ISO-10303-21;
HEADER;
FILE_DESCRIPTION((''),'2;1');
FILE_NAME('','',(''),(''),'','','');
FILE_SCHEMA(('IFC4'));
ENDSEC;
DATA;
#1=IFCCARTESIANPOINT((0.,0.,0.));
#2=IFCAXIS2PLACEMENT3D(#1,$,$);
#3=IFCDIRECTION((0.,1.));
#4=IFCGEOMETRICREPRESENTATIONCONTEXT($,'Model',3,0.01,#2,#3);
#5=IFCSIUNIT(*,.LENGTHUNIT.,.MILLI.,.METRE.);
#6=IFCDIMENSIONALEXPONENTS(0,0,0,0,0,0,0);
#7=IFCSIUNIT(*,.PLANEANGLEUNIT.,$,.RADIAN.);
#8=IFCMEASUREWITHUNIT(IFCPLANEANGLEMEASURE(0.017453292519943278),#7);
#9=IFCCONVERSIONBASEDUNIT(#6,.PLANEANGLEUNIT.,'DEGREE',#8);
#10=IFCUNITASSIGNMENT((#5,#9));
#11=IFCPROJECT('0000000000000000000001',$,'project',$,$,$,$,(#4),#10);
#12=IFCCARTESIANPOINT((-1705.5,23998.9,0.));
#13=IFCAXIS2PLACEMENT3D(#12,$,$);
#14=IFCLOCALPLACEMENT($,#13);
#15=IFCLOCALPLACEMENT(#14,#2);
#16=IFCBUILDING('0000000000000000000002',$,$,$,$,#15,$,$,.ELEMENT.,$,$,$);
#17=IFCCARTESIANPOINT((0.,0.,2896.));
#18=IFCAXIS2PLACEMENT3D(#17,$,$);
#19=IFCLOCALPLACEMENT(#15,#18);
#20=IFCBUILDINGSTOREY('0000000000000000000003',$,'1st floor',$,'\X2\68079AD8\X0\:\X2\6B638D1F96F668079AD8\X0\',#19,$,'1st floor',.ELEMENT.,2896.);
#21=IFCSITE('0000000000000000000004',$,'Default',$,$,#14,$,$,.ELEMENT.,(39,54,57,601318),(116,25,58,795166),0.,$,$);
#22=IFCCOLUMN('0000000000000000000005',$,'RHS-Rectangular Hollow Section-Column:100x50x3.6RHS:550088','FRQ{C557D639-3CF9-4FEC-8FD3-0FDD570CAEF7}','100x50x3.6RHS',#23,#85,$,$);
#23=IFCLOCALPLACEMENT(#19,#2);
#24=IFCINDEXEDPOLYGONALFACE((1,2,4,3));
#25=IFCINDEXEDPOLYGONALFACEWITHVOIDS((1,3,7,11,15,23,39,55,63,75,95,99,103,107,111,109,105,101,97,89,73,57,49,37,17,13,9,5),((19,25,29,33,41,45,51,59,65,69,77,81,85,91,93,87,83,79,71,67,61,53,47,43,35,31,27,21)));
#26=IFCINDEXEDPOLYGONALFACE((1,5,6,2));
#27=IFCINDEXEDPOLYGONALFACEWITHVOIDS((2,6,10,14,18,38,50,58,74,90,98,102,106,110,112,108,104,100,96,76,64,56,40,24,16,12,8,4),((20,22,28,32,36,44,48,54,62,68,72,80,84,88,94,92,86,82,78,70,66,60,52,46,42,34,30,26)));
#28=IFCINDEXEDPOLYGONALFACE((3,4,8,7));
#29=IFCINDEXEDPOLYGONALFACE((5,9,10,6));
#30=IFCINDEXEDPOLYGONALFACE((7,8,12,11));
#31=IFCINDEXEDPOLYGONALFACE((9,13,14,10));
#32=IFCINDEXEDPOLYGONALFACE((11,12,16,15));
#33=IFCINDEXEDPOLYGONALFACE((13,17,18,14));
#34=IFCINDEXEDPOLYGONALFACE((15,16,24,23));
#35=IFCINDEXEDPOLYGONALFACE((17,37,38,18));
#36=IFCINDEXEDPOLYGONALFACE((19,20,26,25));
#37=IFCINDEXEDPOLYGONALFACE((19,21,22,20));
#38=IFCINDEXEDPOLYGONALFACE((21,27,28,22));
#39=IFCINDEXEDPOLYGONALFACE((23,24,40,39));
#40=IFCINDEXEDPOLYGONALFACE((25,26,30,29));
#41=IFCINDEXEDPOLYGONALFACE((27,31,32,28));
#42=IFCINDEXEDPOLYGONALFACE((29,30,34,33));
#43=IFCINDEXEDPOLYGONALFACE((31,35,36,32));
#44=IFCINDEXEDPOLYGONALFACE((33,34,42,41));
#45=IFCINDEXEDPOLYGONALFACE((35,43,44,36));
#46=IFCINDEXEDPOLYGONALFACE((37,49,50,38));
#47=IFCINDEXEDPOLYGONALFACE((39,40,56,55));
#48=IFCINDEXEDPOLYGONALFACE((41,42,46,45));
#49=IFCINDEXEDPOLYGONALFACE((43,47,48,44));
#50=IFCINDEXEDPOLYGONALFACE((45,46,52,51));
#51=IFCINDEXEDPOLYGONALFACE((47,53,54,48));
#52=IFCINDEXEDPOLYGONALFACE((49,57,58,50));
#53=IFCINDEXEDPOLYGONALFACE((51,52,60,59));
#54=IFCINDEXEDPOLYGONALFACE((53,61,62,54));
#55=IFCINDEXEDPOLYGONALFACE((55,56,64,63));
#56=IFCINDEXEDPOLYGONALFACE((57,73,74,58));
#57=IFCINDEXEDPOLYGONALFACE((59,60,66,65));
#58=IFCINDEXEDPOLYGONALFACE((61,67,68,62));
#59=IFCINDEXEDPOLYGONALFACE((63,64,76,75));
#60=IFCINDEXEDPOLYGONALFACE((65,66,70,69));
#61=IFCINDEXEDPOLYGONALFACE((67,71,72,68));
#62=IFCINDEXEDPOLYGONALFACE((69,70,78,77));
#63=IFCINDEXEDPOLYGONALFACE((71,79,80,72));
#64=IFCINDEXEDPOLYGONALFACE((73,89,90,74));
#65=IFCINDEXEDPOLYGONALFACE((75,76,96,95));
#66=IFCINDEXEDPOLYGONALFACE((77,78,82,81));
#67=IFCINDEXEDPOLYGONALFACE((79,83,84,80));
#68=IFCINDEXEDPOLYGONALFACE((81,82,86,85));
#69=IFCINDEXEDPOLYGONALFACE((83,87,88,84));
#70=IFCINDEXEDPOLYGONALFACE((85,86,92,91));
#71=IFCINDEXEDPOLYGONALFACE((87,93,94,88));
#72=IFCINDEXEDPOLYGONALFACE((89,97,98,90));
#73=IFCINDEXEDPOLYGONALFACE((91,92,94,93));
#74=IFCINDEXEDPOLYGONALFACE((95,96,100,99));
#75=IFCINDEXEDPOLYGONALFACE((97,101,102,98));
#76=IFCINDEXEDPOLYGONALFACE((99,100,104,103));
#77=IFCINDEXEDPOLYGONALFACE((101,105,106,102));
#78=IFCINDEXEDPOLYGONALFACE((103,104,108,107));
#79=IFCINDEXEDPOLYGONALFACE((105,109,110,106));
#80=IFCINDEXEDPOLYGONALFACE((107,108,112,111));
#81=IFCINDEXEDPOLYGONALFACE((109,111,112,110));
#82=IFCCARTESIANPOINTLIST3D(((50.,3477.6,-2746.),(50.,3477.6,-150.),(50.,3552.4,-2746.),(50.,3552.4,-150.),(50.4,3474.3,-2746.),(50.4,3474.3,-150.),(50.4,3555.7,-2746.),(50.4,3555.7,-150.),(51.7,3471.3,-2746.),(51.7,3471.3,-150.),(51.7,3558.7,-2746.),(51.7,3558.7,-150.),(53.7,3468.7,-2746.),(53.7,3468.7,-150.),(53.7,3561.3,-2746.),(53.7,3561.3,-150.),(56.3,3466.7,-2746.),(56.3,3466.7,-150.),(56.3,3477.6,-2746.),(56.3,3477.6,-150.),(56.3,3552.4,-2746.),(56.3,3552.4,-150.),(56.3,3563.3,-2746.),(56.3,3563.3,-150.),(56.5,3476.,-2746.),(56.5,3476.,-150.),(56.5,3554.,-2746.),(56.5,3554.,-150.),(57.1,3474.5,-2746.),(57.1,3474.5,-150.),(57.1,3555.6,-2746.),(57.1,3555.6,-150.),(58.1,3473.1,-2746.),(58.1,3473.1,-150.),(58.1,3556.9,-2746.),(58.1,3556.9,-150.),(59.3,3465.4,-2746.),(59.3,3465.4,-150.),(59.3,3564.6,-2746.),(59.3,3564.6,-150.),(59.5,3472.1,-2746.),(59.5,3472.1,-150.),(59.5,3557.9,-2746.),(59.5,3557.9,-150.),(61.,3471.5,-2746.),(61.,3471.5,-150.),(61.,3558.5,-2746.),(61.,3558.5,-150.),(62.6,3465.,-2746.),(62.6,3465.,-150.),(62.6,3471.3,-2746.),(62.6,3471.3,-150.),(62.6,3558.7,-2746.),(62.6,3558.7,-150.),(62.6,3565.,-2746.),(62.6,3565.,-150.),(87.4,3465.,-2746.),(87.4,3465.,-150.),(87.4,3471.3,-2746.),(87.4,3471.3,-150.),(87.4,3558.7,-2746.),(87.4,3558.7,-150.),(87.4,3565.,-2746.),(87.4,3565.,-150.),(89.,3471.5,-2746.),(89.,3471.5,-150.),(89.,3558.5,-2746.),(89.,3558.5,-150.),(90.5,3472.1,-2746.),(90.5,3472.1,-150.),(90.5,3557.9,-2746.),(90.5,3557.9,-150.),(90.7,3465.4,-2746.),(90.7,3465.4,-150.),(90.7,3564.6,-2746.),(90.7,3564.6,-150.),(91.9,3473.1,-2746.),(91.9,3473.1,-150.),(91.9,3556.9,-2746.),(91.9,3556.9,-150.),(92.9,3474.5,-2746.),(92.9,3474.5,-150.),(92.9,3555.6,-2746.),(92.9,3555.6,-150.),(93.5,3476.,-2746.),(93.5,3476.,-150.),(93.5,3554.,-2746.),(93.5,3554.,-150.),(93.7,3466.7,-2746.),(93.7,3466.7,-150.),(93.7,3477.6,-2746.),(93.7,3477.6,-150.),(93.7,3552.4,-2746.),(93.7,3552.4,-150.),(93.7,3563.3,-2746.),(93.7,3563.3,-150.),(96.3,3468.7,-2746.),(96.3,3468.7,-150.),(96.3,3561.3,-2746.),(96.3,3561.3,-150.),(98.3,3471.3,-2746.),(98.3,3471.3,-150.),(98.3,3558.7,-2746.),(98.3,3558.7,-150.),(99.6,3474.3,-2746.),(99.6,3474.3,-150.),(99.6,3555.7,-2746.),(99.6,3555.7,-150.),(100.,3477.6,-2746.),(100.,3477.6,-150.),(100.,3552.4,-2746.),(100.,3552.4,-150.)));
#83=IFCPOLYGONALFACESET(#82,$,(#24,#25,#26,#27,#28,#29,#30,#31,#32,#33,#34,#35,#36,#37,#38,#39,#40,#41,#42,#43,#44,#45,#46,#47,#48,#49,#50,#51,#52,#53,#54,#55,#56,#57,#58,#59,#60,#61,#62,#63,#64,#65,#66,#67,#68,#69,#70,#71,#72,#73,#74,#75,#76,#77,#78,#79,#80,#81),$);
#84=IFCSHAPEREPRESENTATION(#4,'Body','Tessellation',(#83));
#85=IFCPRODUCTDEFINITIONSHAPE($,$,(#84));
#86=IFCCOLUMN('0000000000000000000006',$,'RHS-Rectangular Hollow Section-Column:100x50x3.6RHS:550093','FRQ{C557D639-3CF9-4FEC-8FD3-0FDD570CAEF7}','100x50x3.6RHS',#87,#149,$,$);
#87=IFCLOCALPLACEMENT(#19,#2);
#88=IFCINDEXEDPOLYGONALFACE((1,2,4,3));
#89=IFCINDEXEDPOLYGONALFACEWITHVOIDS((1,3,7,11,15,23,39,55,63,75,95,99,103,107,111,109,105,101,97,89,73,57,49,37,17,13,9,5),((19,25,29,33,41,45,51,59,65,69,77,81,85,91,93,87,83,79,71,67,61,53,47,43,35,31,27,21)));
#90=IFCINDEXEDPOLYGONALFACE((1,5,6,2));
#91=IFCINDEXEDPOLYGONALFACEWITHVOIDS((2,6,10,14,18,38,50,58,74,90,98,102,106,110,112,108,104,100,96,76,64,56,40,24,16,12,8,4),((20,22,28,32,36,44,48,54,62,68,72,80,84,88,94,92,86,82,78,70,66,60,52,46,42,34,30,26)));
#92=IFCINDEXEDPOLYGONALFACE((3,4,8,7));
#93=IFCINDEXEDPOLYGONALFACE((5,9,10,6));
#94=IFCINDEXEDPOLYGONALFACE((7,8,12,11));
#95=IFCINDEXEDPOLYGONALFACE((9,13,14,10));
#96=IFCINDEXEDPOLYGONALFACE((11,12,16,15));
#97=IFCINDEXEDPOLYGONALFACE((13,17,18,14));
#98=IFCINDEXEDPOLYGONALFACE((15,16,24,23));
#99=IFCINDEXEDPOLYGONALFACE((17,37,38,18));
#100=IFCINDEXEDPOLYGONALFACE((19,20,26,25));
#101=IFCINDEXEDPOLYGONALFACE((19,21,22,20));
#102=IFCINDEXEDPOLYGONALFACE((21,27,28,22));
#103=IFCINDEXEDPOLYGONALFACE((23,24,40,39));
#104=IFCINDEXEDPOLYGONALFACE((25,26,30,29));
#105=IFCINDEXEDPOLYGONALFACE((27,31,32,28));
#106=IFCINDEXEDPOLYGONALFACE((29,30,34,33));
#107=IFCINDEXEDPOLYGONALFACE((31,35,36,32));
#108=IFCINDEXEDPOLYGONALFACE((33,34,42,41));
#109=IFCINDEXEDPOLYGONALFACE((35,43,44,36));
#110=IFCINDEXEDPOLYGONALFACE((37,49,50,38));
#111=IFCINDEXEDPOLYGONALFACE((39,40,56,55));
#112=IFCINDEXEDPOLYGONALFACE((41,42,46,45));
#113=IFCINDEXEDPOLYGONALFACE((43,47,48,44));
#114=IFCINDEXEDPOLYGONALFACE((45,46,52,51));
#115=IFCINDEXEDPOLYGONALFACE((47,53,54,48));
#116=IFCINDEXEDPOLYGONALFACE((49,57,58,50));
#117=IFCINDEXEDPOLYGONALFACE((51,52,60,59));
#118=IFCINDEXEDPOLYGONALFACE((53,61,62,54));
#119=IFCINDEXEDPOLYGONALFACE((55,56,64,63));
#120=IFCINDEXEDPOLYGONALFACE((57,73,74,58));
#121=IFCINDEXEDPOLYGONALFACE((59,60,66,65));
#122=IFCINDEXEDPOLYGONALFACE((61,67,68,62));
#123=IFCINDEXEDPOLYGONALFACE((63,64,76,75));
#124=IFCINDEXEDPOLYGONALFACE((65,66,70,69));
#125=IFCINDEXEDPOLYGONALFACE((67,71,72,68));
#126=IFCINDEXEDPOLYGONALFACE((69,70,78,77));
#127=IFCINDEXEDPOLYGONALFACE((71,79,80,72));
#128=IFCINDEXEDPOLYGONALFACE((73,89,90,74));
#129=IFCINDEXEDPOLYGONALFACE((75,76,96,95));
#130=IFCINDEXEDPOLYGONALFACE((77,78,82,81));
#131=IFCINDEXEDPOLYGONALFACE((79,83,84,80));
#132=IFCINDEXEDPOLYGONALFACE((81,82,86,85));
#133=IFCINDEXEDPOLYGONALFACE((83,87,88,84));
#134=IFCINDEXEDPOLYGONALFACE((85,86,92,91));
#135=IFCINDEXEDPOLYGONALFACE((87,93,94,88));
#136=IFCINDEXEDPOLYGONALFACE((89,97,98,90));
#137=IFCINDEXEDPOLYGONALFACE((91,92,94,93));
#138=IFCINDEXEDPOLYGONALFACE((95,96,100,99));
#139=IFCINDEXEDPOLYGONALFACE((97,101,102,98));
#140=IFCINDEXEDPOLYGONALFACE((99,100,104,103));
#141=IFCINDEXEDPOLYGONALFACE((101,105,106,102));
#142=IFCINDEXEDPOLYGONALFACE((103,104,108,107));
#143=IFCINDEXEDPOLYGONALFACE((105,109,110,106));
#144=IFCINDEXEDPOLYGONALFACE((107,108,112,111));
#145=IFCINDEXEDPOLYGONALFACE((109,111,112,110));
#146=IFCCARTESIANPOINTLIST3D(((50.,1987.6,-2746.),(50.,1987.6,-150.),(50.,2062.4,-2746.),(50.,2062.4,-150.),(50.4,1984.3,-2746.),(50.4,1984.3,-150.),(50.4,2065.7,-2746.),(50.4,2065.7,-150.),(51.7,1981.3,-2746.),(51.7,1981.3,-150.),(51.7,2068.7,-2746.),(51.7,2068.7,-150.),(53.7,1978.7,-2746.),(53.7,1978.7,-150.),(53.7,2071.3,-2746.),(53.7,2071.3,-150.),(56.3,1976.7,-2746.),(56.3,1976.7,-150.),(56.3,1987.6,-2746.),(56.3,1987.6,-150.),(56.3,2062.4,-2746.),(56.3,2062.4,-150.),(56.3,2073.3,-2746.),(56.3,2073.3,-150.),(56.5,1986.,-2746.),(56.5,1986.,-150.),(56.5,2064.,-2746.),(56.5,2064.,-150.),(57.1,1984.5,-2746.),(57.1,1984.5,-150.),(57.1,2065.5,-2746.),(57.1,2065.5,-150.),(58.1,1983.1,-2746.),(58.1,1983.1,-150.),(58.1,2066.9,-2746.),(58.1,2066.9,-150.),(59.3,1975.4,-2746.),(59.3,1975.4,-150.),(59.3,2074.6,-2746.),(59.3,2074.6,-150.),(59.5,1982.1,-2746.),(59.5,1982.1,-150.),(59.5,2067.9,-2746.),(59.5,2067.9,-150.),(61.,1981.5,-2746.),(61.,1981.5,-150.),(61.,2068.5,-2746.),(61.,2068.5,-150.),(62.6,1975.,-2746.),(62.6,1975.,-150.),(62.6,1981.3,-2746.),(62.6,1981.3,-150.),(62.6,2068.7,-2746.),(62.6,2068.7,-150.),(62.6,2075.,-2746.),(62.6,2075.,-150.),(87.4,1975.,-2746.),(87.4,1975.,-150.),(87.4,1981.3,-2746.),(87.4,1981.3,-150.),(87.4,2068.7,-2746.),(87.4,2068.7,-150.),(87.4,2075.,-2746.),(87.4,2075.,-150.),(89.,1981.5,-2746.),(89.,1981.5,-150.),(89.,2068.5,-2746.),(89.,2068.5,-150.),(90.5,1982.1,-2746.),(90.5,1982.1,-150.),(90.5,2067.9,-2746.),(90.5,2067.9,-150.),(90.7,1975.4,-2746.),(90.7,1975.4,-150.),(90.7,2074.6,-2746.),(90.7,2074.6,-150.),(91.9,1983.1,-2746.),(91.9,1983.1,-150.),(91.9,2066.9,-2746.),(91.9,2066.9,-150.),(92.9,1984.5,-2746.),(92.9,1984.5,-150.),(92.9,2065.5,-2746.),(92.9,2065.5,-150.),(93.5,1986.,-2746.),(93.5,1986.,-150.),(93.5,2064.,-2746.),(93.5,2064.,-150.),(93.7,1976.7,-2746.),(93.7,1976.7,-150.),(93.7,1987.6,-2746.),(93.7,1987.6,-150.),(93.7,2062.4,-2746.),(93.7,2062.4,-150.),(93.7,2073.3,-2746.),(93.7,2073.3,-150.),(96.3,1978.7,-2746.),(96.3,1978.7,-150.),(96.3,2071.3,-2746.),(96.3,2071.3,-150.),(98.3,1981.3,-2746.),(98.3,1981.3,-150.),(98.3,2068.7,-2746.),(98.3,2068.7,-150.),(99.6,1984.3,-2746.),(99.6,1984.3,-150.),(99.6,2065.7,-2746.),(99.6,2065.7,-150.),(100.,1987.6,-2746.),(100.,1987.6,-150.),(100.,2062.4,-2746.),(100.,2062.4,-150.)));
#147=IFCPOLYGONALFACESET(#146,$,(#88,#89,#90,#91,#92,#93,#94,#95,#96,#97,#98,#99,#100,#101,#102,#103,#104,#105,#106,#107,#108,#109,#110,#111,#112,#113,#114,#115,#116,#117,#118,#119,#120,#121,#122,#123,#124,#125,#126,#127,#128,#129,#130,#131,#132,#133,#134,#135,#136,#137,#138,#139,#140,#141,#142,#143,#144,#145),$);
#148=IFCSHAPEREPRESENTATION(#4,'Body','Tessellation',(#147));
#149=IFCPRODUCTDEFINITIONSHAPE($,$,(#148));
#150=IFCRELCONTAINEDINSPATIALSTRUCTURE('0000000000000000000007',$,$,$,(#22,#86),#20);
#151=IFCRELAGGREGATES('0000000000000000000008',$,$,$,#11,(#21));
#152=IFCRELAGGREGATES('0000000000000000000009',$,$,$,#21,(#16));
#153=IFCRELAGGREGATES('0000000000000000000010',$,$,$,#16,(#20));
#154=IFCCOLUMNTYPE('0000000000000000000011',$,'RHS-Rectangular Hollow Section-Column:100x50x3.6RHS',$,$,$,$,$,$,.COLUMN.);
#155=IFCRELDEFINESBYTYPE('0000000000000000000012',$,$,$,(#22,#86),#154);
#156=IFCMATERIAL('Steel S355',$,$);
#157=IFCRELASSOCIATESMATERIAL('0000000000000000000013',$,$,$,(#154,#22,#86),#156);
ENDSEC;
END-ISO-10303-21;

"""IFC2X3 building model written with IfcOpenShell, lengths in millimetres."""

from ifc_helpers import new_model, entity, si_unit, converted_unit, direction, frame, origin, origin_2d, place, context, project, spatial, hollow_rectangle, extrude, clip, halfspace, material, type_object, element, save


model = new_model("IFC2X3")

# Units and contexts
model_context = context("Model", 3, precision=0.01, world=origin(), true_north=direction((0.0, 1.0)))
ifc_project = project(units=[si_unit("LENGTHUNIT", "METRE", prefix="MILLI"), converted_unit("PLANEANGLEUNIT", "DEGREE", entity("IfcPlaneAngleMeasure", 0.017453292519943278), si_unit("PLANEANGLEUNIT", "RADIAN"), dimensions=[0, 0, 0, 0, 0, 0, 0])], contexts=[model_context])

# Site, building, storey
site_placement = place(None, frame((-1705.5, 23998.9, 0.0)))
site = spatial("IfcSite", under=ifc_project, at=site_placement, Name="Default", CompositionType="ELEMENT", RefLatitude=(39, 54, 57, 601318), RefLongitude=(116, 25, 58, 795166), RefElevation=0.0)
building_placement = place(site_placement, origin())
building = spatial("IfcBuilding", under=site, at=building_placement, CompositionType="ELEMENT")
storey_placement = place(building_placement, frame((0.0, 0.0, 2896.0)))
storey = spatial("IfcBuildingStorey", under=building, at=storey_placement, Name="1st floor", ObjectType="标高:正负零标高", LongName="1st floor", CompositionType="ELEMENT", Elevation=2896.0)

# Shared definitions
ifc_material_1 = material(Name="Steel S355")

# Columns
column_type_1 = type_object("IfcColumnType", Name="RHS-Rectangular Hollow Section-Column:100x50x3.6RHS", PredefinedType="COLUMN", material=ifc_material_1)
column_1_placement = place(storey_placement, frame((75.0, 3515.0, -150.0), z_axis=(0.0, 0.0, 1.0), x_axis=(-1.0, 0.0, 0.0)))
element("IfcColumn", 1, at=column_1_placement, inside=storey, type_object=column_type_1, material=ifc_material_1, Name="RHS-Rectangular Hollow Section-Column:100x50x3.6RHS:550088", Description="FRQ{C557D639-3CF9-4FEC-8FD3-0FDD570CAEF7}", ObjectType="100x50x3.6RHS", context=model_context, shape_type="Clipping", body=[
    clip(extrude(hollow_rectangle(XDim=50.0, YDim=100.0, WallThickness=6.3, InnerFilletRadius=6.3, OuterFilletRadius=12.6, at=origin_2d()), origin(), (0.0, 0.0, -1.0), 2651.9), halfspace(frame((75.0, 3515.0, -2596.0), z_axis=(0.0, 0.0, 1.0), x_axis=(-1.0, 0.0, 0.0)), True)),
])
column_2_placement = place(storey_placement, frame((75.0, 2025.0, -150.0), z_axis=(0.0, 0.0, 1.0), x_axis=(-1.0, 0.0, 0.0)))
element("IfcColumn", 2, at=column_2_placement, inside=storey, type_object=column_type_1, material=ifc_material_1, Name="RHS-Rectangular Hollow Section-Column:100x50x3.6RHS:550093", Description="FRQ{C557D639-3CF9-4FEC-8FD3-0FDD570CAEF7}", ObjectType="100x50x3.6RHS", context=model_context, shape_type="Clipping", body=[
    clip(extrude(hollow_rectangle(XDim=50.0, YDim=100.0, WallThickness=6.3, InnerFilletRadius=6.3, OuterFilletRadius=12.6, at=origin_2d()), origin(), (0.0, 0.0, -1.0), 2651.9), halfspace(frame((75.0, 2025.0, -2596.0), z_axis=(0.0, 0.0, 1.0), x_axis=(-1.0, 0.0, 0.0)), True)),
])

save(model, "model.ifc")
